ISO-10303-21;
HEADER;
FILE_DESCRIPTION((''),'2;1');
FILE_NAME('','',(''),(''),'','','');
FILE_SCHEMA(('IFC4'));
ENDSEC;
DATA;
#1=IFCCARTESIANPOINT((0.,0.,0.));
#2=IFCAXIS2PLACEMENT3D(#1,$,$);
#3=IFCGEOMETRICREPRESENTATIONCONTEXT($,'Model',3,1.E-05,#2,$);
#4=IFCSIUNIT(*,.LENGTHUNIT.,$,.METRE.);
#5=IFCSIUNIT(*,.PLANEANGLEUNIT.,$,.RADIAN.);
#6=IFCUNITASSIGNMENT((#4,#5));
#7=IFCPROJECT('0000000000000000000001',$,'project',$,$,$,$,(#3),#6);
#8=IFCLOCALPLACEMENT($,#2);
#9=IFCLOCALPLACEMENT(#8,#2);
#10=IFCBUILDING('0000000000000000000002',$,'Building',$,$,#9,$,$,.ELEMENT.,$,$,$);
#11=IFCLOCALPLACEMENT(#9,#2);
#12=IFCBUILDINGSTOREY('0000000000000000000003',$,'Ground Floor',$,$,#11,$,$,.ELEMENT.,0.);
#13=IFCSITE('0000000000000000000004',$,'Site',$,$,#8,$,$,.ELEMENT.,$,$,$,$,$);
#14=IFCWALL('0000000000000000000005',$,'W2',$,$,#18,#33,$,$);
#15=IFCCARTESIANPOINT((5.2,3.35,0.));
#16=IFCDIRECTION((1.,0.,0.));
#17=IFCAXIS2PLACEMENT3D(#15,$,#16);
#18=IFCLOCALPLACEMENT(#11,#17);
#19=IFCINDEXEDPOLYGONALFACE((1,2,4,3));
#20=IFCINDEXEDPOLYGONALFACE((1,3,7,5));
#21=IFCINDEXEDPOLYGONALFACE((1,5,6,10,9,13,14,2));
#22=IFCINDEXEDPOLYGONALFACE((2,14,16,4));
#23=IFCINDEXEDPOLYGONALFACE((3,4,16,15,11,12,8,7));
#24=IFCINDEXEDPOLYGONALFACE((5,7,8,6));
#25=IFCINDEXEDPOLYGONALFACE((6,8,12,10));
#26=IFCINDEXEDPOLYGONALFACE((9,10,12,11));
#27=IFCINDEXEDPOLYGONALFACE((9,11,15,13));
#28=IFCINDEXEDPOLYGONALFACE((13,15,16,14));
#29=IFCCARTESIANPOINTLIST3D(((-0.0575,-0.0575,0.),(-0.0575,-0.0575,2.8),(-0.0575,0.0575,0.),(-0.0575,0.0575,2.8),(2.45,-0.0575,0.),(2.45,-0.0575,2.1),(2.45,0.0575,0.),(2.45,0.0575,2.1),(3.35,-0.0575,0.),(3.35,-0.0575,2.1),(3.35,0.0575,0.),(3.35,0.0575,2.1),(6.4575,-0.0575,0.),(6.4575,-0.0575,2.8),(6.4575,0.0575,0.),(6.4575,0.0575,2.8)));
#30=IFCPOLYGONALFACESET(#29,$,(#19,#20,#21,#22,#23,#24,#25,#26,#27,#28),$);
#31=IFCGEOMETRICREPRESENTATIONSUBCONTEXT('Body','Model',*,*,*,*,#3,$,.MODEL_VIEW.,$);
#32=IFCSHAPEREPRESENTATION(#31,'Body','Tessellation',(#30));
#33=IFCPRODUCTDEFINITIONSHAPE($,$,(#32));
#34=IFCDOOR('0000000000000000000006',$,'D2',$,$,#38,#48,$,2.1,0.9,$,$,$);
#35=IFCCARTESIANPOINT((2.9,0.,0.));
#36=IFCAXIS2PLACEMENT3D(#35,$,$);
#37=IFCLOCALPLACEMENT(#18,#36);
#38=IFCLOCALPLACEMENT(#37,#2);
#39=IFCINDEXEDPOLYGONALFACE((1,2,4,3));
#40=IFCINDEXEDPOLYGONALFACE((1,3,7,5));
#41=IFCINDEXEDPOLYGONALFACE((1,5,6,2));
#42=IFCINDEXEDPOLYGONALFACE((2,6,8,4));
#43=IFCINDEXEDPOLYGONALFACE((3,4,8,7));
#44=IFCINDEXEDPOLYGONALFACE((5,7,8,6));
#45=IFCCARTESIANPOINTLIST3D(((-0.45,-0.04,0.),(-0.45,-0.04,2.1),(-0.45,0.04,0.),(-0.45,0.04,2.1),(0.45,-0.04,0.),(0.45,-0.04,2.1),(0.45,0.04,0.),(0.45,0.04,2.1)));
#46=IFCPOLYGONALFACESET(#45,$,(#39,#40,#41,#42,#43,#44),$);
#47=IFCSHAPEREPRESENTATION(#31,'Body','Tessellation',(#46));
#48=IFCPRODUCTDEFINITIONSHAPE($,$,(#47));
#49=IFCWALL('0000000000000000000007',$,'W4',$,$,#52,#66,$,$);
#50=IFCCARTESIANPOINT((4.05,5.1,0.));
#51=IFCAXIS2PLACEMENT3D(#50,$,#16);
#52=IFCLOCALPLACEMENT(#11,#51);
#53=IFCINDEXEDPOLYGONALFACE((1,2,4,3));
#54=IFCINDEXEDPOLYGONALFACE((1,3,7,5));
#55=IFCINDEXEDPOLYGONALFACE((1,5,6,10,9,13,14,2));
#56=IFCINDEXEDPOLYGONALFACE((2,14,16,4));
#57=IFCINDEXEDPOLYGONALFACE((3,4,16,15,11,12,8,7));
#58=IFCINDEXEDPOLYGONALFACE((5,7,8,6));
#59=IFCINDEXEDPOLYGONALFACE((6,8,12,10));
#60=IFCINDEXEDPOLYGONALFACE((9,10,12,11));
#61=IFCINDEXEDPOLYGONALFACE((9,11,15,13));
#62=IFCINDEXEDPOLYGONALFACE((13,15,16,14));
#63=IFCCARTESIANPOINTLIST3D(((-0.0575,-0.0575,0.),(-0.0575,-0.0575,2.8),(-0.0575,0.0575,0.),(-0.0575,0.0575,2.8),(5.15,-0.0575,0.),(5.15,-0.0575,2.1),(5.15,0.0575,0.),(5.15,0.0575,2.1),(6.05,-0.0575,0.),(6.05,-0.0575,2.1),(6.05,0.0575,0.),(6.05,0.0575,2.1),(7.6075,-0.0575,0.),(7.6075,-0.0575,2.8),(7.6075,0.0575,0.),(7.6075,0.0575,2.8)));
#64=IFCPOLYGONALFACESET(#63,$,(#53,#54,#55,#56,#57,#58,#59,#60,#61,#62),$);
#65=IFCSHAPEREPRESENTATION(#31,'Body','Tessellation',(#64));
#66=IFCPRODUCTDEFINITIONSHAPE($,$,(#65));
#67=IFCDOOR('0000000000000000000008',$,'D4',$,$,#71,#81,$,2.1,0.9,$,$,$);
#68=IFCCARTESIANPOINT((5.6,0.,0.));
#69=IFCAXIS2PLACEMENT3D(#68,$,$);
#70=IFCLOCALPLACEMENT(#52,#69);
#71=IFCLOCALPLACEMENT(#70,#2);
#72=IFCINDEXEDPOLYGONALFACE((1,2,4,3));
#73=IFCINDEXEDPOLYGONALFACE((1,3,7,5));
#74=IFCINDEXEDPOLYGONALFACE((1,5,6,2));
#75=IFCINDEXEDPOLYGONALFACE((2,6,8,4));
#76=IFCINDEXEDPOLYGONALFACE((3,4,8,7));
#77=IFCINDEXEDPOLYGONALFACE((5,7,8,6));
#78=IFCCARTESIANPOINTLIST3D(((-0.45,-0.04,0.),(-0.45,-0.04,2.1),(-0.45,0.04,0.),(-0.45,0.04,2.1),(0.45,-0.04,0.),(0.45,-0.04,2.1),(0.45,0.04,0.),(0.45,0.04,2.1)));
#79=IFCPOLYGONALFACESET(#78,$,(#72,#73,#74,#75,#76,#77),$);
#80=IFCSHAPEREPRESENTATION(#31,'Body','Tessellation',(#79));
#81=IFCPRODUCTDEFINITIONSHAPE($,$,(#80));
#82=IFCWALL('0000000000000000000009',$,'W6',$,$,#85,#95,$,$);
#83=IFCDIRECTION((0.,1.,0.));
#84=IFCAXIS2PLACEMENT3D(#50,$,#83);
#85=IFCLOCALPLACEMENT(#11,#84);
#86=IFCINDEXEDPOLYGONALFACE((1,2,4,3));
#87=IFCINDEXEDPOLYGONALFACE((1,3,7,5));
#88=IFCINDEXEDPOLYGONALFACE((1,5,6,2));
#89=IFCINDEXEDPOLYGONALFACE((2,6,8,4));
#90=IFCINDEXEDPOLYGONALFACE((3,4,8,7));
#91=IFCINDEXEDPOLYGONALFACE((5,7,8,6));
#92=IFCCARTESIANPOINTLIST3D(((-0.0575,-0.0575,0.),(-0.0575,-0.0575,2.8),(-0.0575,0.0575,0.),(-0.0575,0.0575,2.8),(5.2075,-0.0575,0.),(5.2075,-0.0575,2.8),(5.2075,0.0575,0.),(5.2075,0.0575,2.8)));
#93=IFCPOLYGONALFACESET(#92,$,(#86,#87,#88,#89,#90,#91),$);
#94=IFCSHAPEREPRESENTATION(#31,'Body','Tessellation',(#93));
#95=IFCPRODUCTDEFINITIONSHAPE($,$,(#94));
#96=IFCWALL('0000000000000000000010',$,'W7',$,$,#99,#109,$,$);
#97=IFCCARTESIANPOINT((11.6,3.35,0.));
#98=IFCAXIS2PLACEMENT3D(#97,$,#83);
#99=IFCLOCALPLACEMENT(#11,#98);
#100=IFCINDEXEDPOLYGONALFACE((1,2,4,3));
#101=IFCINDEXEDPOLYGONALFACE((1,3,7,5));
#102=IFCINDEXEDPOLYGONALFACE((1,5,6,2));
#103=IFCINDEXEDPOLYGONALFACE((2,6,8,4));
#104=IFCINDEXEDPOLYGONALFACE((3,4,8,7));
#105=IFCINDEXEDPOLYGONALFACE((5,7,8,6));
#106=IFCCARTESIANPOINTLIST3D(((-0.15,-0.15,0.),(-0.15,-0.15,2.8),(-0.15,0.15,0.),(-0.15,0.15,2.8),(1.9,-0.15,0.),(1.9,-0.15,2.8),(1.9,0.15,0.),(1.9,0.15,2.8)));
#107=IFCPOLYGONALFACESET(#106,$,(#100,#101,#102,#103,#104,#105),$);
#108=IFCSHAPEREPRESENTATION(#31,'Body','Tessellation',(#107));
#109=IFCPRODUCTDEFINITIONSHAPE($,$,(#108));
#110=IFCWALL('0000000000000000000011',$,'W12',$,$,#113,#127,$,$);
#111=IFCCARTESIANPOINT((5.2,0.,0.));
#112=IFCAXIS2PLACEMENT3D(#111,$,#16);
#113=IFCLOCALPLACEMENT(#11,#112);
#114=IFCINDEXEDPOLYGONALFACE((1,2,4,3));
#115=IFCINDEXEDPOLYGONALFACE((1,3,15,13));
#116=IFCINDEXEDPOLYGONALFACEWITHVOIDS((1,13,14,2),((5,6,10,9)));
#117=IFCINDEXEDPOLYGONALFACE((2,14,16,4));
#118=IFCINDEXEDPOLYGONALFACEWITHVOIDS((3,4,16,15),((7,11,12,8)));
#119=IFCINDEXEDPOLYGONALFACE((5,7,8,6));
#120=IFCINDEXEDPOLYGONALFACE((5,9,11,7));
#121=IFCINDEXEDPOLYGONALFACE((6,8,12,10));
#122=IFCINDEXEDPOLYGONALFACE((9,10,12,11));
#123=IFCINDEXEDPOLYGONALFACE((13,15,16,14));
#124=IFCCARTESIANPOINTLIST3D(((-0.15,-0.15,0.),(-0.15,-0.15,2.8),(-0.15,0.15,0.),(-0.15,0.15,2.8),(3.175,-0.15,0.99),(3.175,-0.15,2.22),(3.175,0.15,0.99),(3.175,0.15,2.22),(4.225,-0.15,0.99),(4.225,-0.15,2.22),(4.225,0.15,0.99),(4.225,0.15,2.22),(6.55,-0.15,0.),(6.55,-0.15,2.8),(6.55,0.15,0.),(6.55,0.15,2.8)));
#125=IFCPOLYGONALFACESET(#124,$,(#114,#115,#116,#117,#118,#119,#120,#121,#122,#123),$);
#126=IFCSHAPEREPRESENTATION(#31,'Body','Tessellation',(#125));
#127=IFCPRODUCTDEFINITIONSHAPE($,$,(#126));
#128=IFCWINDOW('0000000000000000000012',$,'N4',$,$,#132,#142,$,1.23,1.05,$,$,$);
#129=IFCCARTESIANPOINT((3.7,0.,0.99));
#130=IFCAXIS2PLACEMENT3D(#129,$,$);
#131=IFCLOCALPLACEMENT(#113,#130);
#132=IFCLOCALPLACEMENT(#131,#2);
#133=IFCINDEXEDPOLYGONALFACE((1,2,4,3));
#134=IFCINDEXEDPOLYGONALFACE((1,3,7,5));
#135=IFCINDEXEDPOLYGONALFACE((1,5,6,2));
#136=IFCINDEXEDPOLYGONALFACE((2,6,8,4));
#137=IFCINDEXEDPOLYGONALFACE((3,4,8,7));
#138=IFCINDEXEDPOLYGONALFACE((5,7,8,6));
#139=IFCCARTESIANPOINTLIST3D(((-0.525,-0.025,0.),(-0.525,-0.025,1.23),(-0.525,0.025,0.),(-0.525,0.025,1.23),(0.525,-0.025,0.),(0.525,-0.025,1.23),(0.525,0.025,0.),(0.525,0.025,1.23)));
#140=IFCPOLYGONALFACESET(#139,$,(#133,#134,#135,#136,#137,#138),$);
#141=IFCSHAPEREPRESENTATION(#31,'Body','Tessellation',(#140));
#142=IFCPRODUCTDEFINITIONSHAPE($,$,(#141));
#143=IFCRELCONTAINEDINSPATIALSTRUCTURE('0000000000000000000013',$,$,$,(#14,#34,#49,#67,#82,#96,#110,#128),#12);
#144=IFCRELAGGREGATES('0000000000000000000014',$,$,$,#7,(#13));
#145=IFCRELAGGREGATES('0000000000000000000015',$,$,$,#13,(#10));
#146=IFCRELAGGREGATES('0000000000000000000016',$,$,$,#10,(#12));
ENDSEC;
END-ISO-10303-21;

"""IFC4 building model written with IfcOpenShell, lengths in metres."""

from ifc_helpers import new_model, si_unit, frame, frame_2d, origin, origin_2d, place, context, subcontext, project, spatial, rectangle, extrude, element, fill, save


model = new_model("IFC4")

# Units and contexts
model_context = context("Model", 3, precision=1e-05, world=origin())
body_context = subcontext(model_context, "Body", "Model", "MODEL_VIEW")
ifc_project = project(units=[si_unit("LENGTHUNIT", "METRE"), si_unit("PLANEANGLEUNIT", "RADIAN")], contexts=[model_context])

# Site, building, storey
site_placement = place(None, origin())
site = spatial("IfcSite", under=ifc_project, at=site_placement, Name="Site", CompositionType="ELEMENT")
building_placement = place(site_placement, origin())
building = spatial("IfcBuilding", under=site, at=building_placement, Name="Building", CompositionType="ELEMENT")
storey_placement = place(building_placement, origin())
storey = spatial("IfcBuildingStorey", under=building, at=storey_placement, Name="Ground Floor", CompositionType="ELEMENT", Elevation=0.0)

# Walls, openings, doors
wall_1_placement = place(storey_placement, frame((5.2, 3.35, 0.0), x_axis=(1.0, 0.0, 0.0)))
wall_1 = element("IfcWall", 1, at=wall_1_placement, inside=storey, Name="W2", context=body_context, shape_type="SweptSolid", body=[
    extrude(rectangle(XDim=6.515, YDim=0.115, at=frame_2d((3.2, 0.0))), origin(), (0.0, 0.0, 1.0), 2.8),
])
opening_1_placement = place(wall_1_placement, frame((2.9, 0.0, 0.0)))
opening_1 = element("IfcOpeningElement", 2, at=opening_1_placement, cuts=wall_1, context=body_context, shape_type="SweptSolid", body=[
    extrude(rectangle(XDim=0.9, YDim=0.215, at=origin_2d()), origin(), (0.0, 0.0, 1.0), 2.1),
])
door_1_placement = place(opening_1_placement, origin())
door_1 = element("IfcDoor", 3, at=door_1_placement, inside=storey, Name="D2", OverallHeight=2.1, OverallWidth=0.9, context=body_context, shape_type="SweptSolid", body=[
    extrude(rectangle(XDim=0.9, YDim=0.08, at=origin_2d()), origin(), (0.0, 0.0, 1.0), 2.1),
])
fill(opening_1, door_1)
wall_2_placement = place(storey_placement, frame((4.05, 5.1, 0.0), x_axis=(1.0, 0.0, 0.0)))
wall_2 = element("IfcWall", 4, at=wall_2_placement, inside=storey, Name="W4", context=body_context, shape_type="SweptSolid", body=[
    extrude(rectangle(XDim=7.665, YDim=0.115, at=frame_2d((3.775, 0.0))), origin(), (0.0, 0.0, 1.0), 2.8),
])
opening_2_placement = place(wall_2_placement, frame((5.6, 0.0, 0.0)))
opening_2 = element("IfcOpeningElement", 5, at=opening_2_placement, cuts=wall_2, context=body_context, shape_type="SweptSolid", body=[
    extrude(rectangle(XDim=0.9, YDim=0.215, at=origin_2d()), origin(), (0.0, 0.0, 1.0), 2.1),
])
door_2_placement = place(opening_2_placement, origin())
door_2 = element("IfcDoor", 6, at=door_2_placement, inside=storey, Name="D4", OverallHeight=2.1, OverallWidth=0.9, context=body_context, shape_type="SweptSolid", body=[
    extrude(rectangle(XDim=0.9, YDim=0.08, at=origin_2d()), origin(), (0.0, 0.0, 1.0), 2.1),
])
fill(opening_2, door_2)

# Walls
wall_3_placement = place(storey_placement, frame((4.05, 5.1, 0.0), x_axis=(0.0, 1.0, 0.0)))
element("IfcWall", 7, at=wall_3_placement, inside=storey, Name="W6", context=body_context, shape_type="SweptSolid", body=[
    extrude(rectangle(XDim=5.265, YDim=0.115, at=frame_2d((2.575, 0.0))), origin(), (0.0, 0.0, 1.0), 2.8),
])
wall_4_placement = place(storey_placement, frame((11.6, 3.35, 0.0), x_axis=(0.0, 1.0, 0.0)))
element("IfcWall", 8, at=wall_4_placement, inside=storey, Name="W7", context=body_context, shape_type="SweptSolid", body=[
    extrude(rectangle(XDim=2.05, YDim=0.3, at=frame_2d((0.875, 0.0))), origin(), (0.0, 0.0, 1.0), 2.8),
])

# Wall, opening, window
wall_5_placement = place(storey_placement, frame((5.2, 0.0, 0.0), x_axis=(1.0, 0.0, 0.0)))
wall_5 = element("IfcWall", 9, at=wall_5_placement, inside=storey, Name="W12", context=body_context, shape_type="SweptSolid", body=[
    extrude(rectangle(XDim=6.7, YDim=0.3, at=frame_2d((3.2, 0.0))), origin(), (0.0, 0.0, 1.0), 2.8),
])
opening_3_placement = place(wall_5_placement, frame((3.7, 0.0, 0.99)))
opening_3 = element("IfcOpeningElement", 10, at=opening_3_placement, cuts=wall_5, context=body_context, shape_type="SweptSolid", body=[
    extrude(rectangle(XDim=1.05, YDim=0.4, at=origin_2d()), origin(), (0.0, 0.0, 1.0), 1.23),
])
window_1_placement = place(opening_3_placement, origin())
window_1 = element("IfcWindow", 11, at=window_1_placement, inside=storey, Name="N4", OverallHeight=1.23, OverallWidth=1.05, context=body_context, shape_type="SweptSolid", body=[
    extrude(rectangle(XDim=1.05, YDim=0.05, at=origin_2d()), origin(), (0.0, 0.0, 1.0), 1.23),
])
fill(opening_3, window_1)

save(model, "model.ifc")
